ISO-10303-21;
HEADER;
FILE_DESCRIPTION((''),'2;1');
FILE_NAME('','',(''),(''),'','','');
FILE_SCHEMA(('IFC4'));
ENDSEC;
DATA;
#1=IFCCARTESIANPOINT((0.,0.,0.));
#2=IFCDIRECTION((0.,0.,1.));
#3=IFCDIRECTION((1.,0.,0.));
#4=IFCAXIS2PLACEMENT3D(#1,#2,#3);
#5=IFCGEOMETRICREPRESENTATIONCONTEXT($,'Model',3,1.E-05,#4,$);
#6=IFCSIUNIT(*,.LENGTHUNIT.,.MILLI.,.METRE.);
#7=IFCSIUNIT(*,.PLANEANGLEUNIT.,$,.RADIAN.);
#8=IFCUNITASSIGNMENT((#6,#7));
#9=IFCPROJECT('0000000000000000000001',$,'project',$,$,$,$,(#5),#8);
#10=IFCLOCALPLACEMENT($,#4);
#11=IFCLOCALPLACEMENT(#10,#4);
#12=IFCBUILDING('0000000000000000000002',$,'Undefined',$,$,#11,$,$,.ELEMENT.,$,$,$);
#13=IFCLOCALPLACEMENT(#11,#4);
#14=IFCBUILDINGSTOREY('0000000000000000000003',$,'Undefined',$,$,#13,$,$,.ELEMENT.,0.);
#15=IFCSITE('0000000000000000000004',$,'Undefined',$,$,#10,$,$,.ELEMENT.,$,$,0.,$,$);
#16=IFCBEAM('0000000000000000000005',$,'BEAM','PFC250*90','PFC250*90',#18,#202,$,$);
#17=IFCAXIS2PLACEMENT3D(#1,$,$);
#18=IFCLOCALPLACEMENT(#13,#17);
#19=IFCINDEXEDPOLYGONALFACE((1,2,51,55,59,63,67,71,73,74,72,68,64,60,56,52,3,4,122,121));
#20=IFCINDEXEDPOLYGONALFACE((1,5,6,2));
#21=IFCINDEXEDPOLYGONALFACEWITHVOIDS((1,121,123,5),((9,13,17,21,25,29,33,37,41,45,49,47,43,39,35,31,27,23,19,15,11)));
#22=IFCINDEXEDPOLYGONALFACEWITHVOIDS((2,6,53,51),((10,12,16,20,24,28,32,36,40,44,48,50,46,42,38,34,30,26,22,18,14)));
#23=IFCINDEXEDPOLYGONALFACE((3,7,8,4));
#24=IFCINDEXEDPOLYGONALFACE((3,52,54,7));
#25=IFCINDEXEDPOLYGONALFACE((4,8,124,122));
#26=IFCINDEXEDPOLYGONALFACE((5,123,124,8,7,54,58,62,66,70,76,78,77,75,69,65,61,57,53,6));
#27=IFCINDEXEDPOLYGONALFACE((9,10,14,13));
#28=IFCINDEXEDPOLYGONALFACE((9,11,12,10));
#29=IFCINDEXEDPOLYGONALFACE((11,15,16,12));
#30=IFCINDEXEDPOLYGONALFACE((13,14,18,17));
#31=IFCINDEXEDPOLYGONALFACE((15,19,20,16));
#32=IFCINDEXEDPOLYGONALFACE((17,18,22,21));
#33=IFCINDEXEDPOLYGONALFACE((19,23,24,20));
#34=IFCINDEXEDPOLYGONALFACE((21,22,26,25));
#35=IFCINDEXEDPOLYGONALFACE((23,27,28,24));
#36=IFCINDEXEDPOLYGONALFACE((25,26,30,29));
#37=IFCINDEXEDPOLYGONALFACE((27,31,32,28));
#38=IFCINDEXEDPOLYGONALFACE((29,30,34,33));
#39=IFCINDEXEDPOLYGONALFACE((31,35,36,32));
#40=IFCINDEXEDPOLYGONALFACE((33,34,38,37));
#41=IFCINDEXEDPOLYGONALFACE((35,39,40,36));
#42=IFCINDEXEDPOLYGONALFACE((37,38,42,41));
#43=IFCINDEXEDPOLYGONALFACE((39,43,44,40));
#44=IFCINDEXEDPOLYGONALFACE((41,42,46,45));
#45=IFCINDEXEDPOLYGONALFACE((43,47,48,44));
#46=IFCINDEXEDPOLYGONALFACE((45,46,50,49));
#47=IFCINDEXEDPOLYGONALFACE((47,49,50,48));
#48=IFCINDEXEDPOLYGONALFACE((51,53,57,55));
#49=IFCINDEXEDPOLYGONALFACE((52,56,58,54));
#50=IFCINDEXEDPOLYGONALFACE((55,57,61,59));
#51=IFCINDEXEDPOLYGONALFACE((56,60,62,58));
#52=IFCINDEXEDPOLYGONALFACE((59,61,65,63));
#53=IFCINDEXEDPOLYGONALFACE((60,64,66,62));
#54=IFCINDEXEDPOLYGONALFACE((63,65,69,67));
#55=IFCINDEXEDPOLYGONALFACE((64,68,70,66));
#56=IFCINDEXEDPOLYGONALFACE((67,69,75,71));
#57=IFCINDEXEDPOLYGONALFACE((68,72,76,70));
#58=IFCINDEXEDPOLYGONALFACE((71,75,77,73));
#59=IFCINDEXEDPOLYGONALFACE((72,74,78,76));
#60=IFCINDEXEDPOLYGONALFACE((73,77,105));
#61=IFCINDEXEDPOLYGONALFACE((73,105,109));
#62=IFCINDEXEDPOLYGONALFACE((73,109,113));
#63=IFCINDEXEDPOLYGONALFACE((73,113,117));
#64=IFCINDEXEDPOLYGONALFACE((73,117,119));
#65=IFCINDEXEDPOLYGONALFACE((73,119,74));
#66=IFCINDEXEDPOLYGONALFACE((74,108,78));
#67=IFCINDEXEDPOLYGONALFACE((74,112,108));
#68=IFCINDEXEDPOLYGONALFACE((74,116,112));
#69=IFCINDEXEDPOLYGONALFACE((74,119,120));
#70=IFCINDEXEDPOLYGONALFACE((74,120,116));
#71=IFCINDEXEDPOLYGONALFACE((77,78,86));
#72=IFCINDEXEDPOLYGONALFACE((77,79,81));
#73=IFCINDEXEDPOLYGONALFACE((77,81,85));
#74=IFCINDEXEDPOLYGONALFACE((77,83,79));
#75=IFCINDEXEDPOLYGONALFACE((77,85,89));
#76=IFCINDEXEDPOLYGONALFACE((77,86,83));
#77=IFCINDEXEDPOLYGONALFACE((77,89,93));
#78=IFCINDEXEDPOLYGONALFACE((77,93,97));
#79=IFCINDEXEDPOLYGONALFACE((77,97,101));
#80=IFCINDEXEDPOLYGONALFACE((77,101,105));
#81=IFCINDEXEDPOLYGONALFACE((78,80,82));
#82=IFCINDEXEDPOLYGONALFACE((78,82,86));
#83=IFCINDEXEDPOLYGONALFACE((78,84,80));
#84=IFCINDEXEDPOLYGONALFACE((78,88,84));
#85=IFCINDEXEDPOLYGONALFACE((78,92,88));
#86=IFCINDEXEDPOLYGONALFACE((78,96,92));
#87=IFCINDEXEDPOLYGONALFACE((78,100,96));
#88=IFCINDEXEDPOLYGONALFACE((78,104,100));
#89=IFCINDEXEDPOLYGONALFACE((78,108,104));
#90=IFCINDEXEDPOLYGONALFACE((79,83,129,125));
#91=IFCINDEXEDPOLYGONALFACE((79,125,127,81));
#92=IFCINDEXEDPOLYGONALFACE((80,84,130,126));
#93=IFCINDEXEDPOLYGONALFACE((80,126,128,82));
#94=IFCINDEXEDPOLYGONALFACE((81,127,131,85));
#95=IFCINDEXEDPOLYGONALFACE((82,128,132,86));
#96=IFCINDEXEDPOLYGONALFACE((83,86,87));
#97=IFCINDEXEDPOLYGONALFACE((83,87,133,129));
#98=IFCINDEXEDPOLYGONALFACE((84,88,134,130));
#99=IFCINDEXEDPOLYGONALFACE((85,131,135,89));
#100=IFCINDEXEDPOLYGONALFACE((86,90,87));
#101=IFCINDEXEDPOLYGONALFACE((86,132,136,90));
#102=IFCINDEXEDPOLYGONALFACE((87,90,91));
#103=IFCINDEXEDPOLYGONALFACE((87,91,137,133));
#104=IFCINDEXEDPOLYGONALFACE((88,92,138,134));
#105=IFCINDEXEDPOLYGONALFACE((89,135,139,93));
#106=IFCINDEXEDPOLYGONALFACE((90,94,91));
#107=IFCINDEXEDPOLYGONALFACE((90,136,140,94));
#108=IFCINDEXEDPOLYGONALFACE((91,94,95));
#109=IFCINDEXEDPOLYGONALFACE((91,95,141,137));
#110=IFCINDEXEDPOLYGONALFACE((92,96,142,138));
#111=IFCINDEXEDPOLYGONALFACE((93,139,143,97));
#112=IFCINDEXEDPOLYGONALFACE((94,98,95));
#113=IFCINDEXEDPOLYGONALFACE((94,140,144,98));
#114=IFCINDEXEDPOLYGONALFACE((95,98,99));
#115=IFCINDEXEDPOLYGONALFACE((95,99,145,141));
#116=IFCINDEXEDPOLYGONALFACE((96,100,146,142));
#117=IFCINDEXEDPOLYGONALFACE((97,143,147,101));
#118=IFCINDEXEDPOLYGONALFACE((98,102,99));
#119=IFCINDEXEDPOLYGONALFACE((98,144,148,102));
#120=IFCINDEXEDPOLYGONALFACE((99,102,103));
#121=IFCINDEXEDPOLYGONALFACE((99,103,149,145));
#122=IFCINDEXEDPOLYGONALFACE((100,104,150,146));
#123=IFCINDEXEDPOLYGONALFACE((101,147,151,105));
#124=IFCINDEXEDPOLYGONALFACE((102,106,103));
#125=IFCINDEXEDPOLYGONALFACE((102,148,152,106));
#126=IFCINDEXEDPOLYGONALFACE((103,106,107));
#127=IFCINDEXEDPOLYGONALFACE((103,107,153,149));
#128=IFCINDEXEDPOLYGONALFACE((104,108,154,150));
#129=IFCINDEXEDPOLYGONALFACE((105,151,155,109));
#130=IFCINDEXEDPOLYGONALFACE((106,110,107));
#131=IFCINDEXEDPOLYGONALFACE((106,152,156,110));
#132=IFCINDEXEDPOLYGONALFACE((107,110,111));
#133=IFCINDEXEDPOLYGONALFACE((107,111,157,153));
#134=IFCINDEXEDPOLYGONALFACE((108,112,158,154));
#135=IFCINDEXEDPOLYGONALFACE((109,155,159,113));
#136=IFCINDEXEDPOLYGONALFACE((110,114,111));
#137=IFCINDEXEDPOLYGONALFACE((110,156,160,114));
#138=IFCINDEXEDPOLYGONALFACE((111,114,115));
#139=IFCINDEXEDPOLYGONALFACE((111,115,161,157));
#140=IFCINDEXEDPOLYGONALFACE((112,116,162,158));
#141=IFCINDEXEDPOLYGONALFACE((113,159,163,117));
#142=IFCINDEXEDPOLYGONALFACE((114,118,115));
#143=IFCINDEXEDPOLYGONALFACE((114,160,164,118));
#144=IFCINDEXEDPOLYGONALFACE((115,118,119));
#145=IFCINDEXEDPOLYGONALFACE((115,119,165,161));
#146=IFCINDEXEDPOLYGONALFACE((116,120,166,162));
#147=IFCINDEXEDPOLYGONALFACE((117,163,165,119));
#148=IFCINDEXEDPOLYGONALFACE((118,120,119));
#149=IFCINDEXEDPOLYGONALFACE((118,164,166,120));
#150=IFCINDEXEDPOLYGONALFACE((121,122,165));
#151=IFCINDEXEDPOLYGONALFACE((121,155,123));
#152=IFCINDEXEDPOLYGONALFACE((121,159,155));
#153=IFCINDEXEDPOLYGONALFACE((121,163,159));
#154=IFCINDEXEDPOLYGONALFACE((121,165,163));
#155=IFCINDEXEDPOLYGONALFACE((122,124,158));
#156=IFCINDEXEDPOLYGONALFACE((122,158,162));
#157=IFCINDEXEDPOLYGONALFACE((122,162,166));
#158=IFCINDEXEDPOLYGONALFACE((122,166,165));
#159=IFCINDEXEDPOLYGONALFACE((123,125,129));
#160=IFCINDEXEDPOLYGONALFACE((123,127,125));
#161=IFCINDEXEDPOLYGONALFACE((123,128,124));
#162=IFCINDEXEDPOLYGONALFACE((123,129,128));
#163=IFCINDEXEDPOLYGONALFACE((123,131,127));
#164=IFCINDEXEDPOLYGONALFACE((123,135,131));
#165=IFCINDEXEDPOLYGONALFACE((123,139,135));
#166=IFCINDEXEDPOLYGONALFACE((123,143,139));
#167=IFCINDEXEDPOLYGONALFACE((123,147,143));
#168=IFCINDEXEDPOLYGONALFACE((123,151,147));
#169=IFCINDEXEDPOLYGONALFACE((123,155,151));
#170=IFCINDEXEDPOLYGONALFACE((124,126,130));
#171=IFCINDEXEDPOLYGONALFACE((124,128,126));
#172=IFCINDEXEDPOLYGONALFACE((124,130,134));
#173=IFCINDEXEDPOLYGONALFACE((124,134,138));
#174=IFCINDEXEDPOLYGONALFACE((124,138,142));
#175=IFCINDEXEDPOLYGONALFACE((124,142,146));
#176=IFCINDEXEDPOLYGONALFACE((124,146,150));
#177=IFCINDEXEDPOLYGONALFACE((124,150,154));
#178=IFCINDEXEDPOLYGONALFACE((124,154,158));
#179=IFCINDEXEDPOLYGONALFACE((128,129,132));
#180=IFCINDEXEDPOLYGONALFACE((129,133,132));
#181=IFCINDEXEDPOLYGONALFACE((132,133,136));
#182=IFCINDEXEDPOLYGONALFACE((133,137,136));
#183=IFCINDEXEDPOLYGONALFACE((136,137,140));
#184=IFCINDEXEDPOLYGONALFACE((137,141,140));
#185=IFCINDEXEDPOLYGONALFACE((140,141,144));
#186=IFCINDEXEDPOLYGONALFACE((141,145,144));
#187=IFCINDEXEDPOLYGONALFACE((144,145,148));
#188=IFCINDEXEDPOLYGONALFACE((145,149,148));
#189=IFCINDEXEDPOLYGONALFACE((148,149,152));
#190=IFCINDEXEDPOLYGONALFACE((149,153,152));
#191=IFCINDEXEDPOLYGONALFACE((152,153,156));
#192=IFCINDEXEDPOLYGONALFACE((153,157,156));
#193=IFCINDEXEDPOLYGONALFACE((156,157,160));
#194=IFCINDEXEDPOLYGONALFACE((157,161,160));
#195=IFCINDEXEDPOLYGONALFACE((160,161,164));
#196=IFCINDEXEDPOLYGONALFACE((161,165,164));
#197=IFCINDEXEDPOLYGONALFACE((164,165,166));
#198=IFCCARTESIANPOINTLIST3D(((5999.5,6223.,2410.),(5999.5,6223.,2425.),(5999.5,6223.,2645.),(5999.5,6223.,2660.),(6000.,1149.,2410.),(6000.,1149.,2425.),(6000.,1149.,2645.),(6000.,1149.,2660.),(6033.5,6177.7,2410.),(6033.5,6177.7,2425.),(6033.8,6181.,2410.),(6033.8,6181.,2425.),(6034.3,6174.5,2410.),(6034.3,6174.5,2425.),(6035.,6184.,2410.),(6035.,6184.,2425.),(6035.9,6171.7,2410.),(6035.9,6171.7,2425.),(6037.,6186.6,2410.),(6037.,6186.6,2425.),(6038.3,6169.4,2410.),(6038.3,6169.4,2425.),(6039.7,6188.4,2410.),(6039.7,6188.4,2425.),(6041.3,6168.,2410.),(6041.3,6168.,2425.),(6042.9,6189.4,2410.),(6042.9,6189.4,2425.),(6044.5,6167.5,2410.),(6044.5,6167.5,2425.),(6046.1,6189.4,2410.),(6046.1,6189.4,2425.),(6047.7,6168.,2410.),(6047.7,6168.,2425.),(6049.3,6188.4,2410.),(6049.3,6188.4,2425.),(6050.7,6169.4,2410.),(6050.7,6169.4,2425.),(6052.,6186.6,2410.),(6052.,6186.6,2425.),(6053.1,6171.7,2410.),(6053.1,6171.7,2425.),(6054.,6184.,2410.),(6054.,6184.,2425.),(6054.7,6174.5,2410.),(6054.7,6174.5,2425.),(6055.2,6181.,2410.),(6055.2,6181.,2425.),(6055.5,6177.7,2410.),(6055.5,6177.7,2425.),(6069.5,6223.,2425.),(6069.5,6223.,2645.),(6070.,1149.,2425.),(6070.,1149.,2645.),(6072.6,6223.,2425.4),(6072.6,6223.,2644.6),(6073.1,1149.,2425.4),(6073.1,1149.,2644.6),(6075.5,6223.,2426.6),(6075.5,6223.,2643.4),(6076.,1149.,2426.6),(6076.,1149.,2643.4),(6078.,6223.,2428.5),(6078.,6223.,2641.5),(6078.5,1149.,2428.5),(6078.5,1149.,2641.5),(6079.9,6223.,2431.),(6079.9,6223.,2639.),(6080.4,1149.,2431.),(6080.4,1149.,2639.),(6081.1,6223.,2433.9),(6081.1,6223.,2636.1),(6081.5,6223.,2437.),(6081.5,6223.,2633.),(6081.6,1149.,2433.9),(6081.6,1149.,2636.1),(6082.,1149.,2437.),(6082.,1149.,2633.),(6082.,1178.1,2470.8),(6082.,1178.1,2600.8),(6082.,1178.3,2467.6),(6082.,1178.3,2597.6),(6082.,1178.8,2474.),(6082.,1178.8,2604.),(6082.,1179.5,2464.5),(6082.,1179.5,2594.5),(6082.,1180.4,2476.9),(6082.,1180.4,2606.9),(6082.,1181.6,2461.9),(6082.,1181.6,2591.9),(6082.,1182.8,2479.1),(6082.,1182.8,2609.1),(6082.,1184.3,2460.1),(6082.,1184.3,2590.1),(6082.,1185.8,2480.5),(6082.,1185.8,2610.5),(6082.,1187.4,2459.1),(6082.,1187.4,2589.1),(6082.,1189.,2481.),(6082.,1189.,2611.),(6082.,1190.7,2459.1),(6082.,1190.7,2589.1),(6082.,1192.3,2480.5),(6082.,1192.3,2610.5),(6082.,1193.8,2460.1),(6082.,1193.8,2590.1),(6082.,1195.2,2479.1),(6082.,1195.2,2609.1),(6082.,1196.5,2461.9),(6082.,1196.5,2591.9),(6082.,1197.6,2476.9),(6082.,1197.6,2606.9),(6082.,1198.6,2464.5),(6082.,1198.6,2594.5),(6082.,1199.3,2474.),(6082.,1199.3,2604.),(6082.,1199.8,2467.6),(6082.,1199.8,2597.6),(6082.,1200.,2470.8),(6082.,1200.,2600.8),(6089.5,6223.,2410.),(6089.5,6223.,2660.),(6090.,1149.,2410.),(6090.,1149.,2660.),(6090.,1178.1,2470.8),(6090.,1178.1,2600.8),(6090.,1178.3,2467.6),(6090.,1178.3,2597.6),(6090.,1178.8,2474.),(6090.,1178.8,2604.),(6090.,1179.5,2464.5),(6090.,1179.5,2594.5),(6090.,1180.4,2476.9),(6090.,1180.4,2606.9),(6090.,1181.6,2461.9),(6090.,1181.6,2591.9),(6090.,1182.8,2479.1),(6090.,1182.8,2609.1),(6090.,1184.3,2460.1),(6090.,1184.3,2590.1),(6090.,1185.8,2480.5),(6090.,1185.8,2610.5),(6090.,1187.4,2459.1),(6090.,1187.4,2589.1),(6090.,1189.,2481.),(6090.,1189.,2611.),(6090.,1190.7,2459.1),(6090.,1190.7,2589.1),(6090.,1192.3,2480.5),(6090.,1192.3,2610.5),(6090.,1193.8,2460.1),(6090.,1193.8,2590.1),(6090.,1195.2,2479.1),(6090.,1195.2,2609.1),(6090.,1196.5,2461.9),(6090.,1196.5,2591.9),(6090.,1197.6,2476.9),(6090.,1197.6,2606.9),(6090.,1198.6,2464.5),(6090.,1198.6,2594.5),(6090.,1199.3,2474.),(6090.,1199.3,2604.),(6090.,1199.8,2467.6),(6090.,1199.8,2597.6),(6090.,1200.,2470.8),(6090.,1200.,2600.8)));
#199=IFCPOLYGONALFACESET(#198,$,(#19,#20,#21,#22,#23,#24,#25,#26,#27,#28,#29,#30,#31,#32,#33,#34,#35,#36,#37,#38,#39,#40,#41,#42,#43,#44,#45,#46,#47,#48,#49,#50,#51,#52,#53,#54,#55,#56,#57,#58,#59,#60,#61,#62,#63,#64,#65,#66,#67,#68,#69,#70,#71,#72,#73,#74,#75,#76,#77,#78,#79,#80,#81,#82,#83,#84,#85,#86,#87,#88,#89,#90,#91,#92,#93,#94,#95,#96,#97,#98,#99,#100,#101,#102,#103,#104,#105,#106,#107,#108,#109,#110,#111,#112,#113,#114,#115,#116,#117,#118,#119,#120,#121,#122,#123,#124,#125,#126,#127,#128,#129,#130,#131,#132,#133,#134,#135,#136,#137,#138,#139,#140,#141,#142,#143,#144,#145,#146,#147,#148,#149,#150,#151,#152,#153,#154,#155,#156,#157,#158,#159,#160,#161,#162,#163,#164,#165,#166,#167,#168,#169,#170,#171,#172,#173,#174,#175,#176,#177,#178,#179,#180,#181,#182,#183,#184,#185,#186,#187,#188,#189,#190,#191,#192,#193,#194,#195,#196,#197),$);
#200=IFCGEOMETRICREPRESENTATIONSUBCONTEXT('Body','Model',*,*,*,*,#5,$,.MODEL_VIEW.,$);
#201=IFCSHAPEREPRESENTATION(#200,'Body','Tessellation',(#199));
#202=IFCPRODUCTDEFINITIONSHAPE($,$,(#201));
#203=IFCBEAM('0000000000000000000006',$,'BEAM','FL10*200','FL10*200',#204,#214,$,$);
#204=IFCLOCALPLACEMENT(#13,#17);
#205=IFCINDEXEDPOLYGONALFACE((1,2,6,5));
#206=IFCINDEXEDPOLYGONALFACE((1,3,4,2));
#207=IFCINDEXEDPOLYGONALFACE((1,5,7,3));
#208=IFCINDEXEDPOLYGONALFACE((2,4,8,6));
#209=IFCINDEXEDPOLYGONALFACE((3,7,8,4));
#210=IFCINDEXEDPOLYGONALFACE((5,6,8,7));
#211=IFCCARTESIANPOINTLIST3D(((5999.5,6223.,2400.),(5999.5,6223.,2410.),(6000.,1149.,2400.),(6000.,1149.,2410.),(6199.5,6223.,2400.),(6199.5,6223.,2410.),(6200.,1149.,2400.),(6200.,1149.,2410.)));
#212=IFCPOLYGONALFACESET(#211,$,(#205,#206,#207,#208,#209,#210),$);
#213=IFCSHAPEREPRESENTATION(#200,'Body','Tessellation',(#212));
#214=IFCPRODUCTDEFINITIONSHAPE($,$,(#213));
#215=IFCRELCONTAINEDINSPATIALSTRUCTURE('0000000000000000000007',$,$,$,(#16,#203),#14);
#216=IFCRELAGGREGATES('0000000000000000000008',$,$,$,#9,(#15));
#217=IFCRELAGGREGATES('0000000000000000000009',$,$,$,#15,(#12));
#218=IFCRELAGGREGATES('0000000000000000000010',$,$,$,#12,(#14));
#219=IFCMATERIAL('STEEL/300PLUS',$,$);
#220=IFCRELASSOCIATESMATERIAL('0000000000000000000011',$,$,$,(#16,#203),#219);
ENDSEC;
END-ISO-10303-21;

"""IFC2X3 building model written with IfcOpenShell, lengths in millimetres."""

from ifc_helpers import new_model, si_unit, frame, origin_with_axes, origin_2d_with_axis, place, context, subcontext, project, spatial, rectangle, circle, u_section, extrude, clip, halfspace, source, transform, mapped, material, element, save


model = new_model("IFC2X3")

# Units and contexts
model_context = context("Model", 3, precision=1e-05, world=origin_with_axes())
body_context = subcontext(model_context, "Body", "Model", "MODEL_VIEW")
ifc_project = project(units=[si_unit("LENGTHUNIT", "METRE", prefix="MILLI"), si_unit("PLANEANGLEUNIT", "RADIAN")], contexts=[model_context])

# Site, building, storey
site_placement = place(None, origin_with_axes())
site = spatial("IfcSite", under=ifc_project, at=site_placement, Name="Undefined", CompositionType="ELEMENT", RefElevation=0.0)
building_placement = place(site_placement, origin_with_axes())
building = spatial("IfcBuilding", under=site, at=building_placement, Name="Undefined", CompositionType="ELEMENT")
storey_placement = place(building_placement, origin_with_axes())
storey = spatial("IfcBuildingStorey", under=building, at=storey_placement, Name="Undefined", CompositionType="ELEMENT", Elevation=0.0)

# Shared definitions
ifc_material_1 = material(Name="STEEL/300PLUS")

# Beam, openings
beam_1_placement = place(storey_placement, frame((6045.0, 1149.0, 2535.0), z_axis=(0.0, 0.0, -1.0), x_axis=(-0.000099, 1.0, 0.0)))
beam_1 = element("IfcBeam", 1, at=beam_1_placement, inside=storey, material=ifc_material_1, Name="BEAM", Description="PFC250*90", ObjectType="PFC250*90", context=body_context, shape_type="Clipping", body=[
    clip(extrude(u_section(Depth=250.0, FlangeWidth=90.0, WebThickness=8.0, FlangeThickness=15.0, FilletRadius=12.0, at=origin_2d_with_axis()), frame((5074.0, 0.0, 0.0), z_axis=(-1.0, 0.0, 0.0), x_axis=(0.0, -1.0, 0.0)), (0.0, 0.0, 1.0), 5074.0), halfspace(frame((0.0, 45.0, -125.0), z_axis=(-1.0, -0.000099, 0.0), x_axis=(0.0, 0.0, 1.0)), False)),
])
shared_shape_1 = source(origin_with_axes(), body_context, "Body", "SweptSolid", [
    extrude(circle(Radius=11.0, at=origin_2d_with_axis()), frame((0.0, 24.9, 0.0), z_axis=(0.0, 1.0, 0.0), x_axis=(1.0, 0.0, 0.0)), (0.0, 0.0, 1.0), 40.1),
])
opening_1_placement = place(storey_placement, frame((6044.5, 6178.5, 2385.0), z_axis=(-1.0, 0.0, 0.0), x_axis=(0.0, -1.0, 0.000008)))
element("IfcOpeningElement", 2, at=opening_1_placement, cuts=beam_1, ObjectType="Opening", context=body_context, shape_type="MappedRepresentation", body=[
    mapped(shared_shape_1, transform((0.0, 0.0, 0.0))),
])
shared_shape_2 = source(origin_with_axes(), body_context, "Body", "SweptSolid", [
    extrude(circle(Radius=11.0, at=origin_2d_with_axis()), frame((0.0, -0.1, 0.0), z_axis=(0.0, 1.0, 0.0), x_axis=(1.0, 0.0, 0.0)), (0.0, 0.0, 1.0), 8.2),
])
opening_2_placement = place(storey_placement, frame((6082.0, 1189.0, 2600.0), z_axis=(0.0, 1.0, 0.0), x_axis=(-0.000022, 0.0, 1.0)))
element("IfcOpeningElement", 3, at=opening_2_placement, cuts=beam_1, ObjectType="Opening", context=body_context, shape_type="MappedRepresentation", body=[
    mapped(shared_shape_2, transform((0.0, 0.0, 0.0))),
])
opening_3_placement = place(storey_placement, frame((6082.0, 1189.0, 2470.0), z_axis=(0.0, 1.0, 0.0), x_axis=(-0.000022, 0.0, 1.0)))
element("IfcOpeningElement", 4, at=opening_3_placement, cuts=beam_1, ObjectType="Opening", context=body_context, shape_type="MappedRepresentation", body=[
    mapped(shared_shape_2, transform((0.0, 0.0, 0.0))),
])

# Beam
beam_2_placement = place(storey_placement, frame((6099.5, 6223.0, 2405.0), z_axis=(-1.0, -0.000099, 0.0), x_axis=(0.000099, -1.0, 0.0)))
element("IfcBeam", 5, at=beam_2_placement, inside=storey, material=ifc_material_1, Name="BEAM", Description="FL10*200", ObjectType="FL10*200", context=body_context, shape_type="SweptSolid", body=[
    extrude(rectangle(XDim=10.0, YDim=200.0, at=origin_2d_with_axis()), frame((5074.0, 0.0, 0.0), z_axis=(-1.0, 0.0, 0.0), x_axis=(0.0, -1.0, 0.0)), (0.0, 0.0, 1.0), 5074.0),
])

save(model, "model.ifc")
